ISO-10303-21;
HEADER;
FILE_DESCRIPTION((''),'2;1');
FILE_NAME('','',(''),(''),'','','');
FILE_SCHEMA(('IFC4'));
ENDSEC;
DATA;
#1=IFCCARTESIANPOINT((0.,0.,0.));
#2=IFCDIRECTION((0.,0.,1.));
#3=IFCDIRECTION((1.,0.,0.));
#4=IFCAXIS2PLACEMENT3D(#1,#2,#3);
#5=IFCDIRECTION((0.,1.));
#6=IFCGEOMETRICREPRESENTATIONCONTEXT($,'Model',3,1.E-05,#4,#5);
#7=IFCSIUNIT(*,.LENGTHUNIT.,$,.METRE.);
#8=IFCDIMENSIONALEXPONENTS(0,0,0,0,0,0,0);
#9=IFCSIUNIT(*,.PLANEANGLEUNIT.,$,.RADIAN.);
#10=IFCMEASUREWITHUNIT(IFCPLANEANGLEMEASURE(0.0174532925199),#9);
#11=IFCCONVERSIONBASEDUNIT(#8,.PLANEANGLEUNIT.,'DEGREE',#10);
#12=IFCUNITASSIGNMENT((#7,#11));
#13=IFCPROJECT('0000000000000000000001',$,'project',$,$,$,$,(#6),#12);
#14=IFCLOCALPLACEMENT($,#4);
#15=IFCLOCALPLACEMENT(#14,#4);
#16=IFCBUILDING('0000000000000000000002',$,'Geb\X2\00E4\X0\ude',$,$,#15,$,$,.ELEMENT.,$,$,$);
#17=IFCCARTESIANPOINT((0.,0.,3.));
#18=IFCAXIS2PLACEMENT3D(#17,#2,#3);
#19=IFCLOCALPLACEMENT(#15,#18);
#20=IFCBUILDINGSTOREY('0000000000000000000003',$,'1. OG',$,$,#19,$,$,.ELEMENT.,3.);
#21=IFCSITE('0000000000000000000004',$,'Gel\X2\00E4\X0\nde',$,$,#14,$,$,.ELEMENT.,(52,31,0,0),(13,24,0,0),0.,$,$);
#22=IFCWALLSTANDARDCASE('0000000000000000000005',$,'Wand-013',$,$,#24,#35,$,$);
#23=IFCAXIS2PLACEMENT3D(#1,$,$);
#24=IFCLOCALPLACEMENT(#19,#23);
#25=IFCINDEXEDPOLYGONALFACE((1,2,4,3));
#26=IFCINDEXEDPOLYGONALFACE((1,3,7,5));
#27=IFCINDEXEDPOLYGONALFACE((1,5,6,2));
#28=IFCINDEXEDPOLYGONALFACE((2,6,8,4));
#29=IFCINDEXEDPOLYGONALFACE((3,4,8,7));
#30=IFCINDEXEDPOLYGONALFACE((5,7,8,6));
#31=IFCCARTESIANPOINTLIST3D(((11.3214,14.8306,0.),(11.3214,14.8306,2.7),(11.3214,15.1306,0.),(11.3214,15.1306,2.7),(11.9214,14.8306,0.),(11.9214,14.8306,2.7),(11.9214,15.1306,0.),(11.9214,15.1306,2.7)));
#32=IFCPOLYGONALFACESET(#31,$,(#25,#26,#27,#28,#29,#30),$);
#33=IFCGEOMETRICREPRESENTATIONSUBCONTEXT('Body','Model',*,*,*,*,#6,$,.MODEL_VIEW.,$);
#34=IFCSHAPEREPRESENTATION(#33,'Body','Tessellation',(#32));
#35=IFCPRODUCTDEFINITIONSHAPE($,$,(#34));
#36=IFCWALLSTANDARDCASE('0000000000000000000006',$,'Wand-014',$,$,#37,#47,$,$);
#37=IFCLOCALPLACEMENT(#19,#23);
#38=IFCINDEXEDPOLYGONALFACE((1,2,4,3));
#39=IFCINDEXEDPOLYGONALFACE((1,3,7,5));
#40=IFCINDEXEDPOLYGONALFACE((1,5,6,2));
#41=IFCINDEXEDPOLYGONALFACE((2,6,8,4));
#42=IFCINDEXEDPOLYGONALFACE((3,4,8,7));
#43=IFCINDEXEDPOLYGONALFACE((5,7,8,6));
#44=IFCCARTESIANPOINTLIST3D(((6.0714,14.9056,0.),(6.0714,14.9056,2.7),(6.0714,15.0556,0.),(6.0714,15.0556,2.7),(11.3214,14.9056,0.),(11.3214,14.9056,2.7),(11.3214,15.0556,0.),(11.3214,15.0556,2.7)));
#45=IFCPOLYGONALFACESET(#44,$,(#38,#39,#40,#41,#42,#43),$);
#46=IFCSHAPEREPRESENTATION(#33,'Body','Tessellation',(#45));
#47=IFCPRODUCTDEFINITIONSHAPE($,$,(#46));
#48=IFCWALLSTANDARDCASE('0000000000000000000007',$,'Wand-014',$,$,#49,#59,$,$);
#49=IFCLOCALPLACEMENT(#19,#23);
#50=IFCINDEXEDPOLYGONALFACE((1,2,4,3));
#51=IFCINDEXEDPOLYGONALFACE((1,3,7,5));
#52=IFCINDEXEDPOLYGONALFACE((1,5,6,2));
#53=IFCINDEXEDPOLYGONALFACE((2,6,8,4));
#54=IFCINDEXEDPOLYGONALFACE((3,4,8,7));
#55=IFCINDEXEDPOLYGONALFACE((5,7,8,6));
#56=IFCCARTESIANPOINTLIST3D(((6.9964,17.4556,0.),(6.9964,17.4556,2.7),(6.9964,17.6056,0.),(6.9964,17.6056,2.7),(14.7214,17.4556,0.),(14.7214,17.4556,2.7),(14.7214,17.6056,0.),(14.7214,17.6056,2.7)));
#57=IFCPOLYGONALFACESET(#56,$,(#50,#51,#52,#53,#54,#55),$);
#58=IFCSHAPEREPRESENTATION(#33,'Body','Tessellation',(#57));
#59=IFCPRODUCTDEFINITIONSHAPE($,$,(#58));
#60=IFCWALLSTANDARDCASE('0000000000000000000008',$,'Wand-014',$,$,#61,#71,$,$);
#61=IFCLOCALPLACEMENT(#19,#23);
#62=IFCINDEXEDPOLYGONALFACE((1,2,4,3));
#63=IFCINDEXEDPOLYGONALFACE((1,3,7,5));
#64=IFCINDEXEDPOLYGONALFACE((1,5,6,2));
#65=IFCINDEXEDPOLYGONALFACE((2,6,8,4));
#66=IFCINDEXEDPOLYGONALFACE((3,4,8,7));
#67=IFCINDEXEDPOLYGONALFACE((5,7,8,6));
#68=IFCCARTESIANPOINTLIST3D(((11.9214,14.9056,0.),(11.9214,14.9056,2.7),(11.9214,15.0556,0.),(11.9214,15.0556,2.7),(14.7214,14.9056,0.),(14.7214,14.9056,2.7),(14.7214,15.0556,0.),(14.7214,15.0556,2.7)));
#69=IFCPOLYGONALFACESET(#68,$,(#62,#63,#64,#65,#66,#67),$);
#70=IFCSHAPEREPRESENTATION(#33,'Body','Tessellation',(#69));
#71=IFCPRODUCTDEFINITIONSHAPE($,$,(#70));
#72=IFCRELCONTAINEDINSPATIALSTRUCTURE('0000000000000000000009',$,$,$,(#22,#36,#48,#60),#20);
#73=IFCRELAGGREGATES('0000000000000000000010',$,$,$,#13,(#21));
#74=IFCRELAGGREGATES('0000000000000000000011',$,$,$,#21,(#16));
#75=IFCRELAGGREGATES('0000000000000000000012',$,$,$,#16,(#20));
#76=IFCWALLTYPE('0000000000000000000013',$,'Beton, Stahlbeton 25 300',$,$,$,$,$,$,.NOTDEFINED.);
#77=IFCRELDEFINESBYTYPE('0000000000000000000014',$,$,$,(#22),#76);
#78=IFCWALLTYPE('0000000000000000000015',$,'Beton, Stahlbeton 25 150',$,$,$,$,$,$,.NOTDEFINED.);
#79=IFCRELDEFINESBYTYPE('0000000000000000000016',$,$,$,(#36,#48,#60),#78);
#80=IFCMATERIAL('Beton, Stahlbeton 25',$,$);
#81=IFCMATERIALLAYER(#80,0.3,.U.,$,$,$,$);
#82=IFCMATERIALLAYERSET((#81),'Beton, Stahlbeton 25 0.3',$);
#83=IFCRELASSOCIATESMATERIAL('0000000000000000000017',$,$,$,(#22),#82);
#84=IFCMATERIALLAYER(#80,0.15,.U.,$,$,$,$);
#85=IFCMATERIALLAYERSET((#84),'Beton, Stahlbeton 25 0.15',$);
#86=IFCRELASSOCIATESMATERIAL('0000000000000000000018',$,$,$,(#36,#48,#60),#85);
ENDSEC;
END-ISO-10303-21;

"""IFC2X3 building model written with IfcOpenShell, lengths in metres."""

from ifc_helpers import new_model, entity, si_unit, converted_unit, direction, frame, origin_with_axes, place, context, subcontext, project, spatial, polyline, outline, extrude, material, layer, layer_set, layer_usage, type_object, element, save


model = new_model("IFC2X3")

# Units and contexts
model_context = context("Model", 3, precision=1e-05, world=origin_with_axes(), true_north=direction((0.0, 1.0)))
body_context = subcontext(model_context, "Body", "Model", "MODEL_VIEW")
ifc_project = project(units=[si_unit("LENGTHUNIT", "METRE"), converted_unit("PLANEANGLEUNIT", "DEGREE", entity("IfcPlaneAngleMeasure", 0.0174532925199), si_unit("PLANEANGLEUNIT", "RADIAN"), dimensions=[0, 0, 0, 0, 0, 0, 0])], contexts=[model_context])

# Site, building, storey
site_placement = place(None, origin_with_axes())
site = spatial("IfcSite", under=ifc_project, at=site_placement, Name="Gelände", CompositionType="ELEMENT", RefLatitude=(52, 31, 0, 0), RefLongitude=(13, 24, 0, 0), RefElevation=0.0)
building_placement = place(site_placement, origin_with_axes())
building = spatial("IfcBuilding", under=site, at=building_placement, Name="Gebäude", CompositionType="ELEMENT")
storey_placement = place(building_placement, frame((0.0, 0.0, 3.0), z_axis=(0.0, 0.0, 1.0), x_axis=(1.0, 0.0, 0.0)))
storey = spatial("IfcBuildingStorey", under=building, at=storey_placement, Name="1. OG", CompositionType="ELEMENT", Elevation=3.0)

# Walls
ifc_material = material(Name="Beton, Stahlbeton 25")
ifc_layer_1 = layer(ifc_material, 0.3, ventilated="UNKNOWN")
ifc_layer_set_1 = layer_set([ifc_layer_1], Name="Beton, Stahlbeton 25 0.3")
ifc_layer_usage_1 = layer_usage(ifc_layer_set_1, "AXIS2", "NEGATIVE", 0.3)
wall_type_1 = type_object("IfcWallType", Name="Beton, Stahlbeton 25 300", PredefinedType="NOTDEFINED")
wall_1_placement = place(storey_placement, frame((11.3214, 14.8306, 0.0), z_axis=(0.0, 0.0, 1.0), x_axis=(1.0, 0.0, 0.0)))
element("IfcWallStandardCase", 1, at=wall_1_placement, inside=storey, type_object=wall_type_1, material=ifc_layer_usage_1, Name="Wand-013", context=body_context, shape_type="SweptSolid", body=[
    extrude(outline(polyline([(0.0, 0.0), (0.6, 0.0), (0.6, 0.3), (0.0, 0.3), (0.0, 0.0)])), origin_with_axes(), (0.0, 0.0, 1.0), 2.7),
])
ifc_layer_2 = layer(ifc_material, 0.15, ventilated="UNKNOWN")
ifc_layer_set_2 = layer_set([ifc_layer_2], Name="Beton, Stahlbeton 25 0.15")
ifc_layer_usage_2 = layer_usage(ifc_layer_set_2, "AXIS2", "NEGATIVE", 0.075)
wall_type_2 = type_object("IfcWallType", Name="Beton, Stahlbeton 25 150", PredefinedType="NOTDEFINED")
wall_2_placement = place(storey_placement, frame((11.3214, 14.9806, 0.0), z_axis=(0.0, 0.0, 1.0), x_axis=(-1.0, 0.0, 0.0)))
element("IfcWallStandardCase", 2, at=wall_2_placement, inside=storey, type_object=wall_type_2, material=ifc_layer_usage_2, Name="Wand-014", context=body_context, shape_type="SweptSolid", body=[
    extrude(outline(polyline([(0.0, -0.075), (5.25, -0.075), (5.25, 0.075), (0.0, 0.075), (0.0, -0.075)])), origin_with_axes(), (0.0, 0.0, 1.0), 2.7),
])
ifc_layer_usage_3 = layer_usage(ifc_layer_set_2, "AXIS2", "NEGATIVE", 0.075)
wall_3_placement = place(storey_placement, frame((14.7214, 17.5306, 0.0), z_axis=(0.0, 0.0, 1.0), x_axis=(-1.0, 0.0, 0.0)))
element("IfcWallStandardCase", 3, at=wall_3_placement, inside=storey, type_object=wall_type_2, material=ifc_layer_usage_3, Name="Wand-014", context=body_context, shape_type="SweptSolid", body=[
    extrude(outline(polyline([(0.0, -0.075), (7.725, -0.075), (7.725, 0.075), (0.0, 0.075), (0.0, -0.075)])), origin_with_axes(), (0.0, 0.0, 1.0), 2.7),
])
ifc_layer_usage_4 = layer_usage(ifc_layer_set_2, "AXIS2", "NEGATIVE", 0.075)
wall_4_placement = place(storey_placement, frame((14.7214, 14.9806, 0.0), z_axis=(0.0, 0.0, 1.0), x_axis=(-1.0, 0.0, 0.0)))
element("IfcWallStandardCase", 4, at=wall_4_placement, inside=storey, type_object=wall_type_2, material=ifc_layer_usage_4, Name="Wand-014", context=body_context, shape_type="SweptSolid", body=[
    extrude(outline(polyline([(0.0, -0.075), (2.8, -0.075), (2.8, 0.075), (0.0, 0.075), (0.0, -0.075)])), origin_with_axes(), (0.0, 0.0, 1.0), 2.7),
])

save(model, "model.ifc")
